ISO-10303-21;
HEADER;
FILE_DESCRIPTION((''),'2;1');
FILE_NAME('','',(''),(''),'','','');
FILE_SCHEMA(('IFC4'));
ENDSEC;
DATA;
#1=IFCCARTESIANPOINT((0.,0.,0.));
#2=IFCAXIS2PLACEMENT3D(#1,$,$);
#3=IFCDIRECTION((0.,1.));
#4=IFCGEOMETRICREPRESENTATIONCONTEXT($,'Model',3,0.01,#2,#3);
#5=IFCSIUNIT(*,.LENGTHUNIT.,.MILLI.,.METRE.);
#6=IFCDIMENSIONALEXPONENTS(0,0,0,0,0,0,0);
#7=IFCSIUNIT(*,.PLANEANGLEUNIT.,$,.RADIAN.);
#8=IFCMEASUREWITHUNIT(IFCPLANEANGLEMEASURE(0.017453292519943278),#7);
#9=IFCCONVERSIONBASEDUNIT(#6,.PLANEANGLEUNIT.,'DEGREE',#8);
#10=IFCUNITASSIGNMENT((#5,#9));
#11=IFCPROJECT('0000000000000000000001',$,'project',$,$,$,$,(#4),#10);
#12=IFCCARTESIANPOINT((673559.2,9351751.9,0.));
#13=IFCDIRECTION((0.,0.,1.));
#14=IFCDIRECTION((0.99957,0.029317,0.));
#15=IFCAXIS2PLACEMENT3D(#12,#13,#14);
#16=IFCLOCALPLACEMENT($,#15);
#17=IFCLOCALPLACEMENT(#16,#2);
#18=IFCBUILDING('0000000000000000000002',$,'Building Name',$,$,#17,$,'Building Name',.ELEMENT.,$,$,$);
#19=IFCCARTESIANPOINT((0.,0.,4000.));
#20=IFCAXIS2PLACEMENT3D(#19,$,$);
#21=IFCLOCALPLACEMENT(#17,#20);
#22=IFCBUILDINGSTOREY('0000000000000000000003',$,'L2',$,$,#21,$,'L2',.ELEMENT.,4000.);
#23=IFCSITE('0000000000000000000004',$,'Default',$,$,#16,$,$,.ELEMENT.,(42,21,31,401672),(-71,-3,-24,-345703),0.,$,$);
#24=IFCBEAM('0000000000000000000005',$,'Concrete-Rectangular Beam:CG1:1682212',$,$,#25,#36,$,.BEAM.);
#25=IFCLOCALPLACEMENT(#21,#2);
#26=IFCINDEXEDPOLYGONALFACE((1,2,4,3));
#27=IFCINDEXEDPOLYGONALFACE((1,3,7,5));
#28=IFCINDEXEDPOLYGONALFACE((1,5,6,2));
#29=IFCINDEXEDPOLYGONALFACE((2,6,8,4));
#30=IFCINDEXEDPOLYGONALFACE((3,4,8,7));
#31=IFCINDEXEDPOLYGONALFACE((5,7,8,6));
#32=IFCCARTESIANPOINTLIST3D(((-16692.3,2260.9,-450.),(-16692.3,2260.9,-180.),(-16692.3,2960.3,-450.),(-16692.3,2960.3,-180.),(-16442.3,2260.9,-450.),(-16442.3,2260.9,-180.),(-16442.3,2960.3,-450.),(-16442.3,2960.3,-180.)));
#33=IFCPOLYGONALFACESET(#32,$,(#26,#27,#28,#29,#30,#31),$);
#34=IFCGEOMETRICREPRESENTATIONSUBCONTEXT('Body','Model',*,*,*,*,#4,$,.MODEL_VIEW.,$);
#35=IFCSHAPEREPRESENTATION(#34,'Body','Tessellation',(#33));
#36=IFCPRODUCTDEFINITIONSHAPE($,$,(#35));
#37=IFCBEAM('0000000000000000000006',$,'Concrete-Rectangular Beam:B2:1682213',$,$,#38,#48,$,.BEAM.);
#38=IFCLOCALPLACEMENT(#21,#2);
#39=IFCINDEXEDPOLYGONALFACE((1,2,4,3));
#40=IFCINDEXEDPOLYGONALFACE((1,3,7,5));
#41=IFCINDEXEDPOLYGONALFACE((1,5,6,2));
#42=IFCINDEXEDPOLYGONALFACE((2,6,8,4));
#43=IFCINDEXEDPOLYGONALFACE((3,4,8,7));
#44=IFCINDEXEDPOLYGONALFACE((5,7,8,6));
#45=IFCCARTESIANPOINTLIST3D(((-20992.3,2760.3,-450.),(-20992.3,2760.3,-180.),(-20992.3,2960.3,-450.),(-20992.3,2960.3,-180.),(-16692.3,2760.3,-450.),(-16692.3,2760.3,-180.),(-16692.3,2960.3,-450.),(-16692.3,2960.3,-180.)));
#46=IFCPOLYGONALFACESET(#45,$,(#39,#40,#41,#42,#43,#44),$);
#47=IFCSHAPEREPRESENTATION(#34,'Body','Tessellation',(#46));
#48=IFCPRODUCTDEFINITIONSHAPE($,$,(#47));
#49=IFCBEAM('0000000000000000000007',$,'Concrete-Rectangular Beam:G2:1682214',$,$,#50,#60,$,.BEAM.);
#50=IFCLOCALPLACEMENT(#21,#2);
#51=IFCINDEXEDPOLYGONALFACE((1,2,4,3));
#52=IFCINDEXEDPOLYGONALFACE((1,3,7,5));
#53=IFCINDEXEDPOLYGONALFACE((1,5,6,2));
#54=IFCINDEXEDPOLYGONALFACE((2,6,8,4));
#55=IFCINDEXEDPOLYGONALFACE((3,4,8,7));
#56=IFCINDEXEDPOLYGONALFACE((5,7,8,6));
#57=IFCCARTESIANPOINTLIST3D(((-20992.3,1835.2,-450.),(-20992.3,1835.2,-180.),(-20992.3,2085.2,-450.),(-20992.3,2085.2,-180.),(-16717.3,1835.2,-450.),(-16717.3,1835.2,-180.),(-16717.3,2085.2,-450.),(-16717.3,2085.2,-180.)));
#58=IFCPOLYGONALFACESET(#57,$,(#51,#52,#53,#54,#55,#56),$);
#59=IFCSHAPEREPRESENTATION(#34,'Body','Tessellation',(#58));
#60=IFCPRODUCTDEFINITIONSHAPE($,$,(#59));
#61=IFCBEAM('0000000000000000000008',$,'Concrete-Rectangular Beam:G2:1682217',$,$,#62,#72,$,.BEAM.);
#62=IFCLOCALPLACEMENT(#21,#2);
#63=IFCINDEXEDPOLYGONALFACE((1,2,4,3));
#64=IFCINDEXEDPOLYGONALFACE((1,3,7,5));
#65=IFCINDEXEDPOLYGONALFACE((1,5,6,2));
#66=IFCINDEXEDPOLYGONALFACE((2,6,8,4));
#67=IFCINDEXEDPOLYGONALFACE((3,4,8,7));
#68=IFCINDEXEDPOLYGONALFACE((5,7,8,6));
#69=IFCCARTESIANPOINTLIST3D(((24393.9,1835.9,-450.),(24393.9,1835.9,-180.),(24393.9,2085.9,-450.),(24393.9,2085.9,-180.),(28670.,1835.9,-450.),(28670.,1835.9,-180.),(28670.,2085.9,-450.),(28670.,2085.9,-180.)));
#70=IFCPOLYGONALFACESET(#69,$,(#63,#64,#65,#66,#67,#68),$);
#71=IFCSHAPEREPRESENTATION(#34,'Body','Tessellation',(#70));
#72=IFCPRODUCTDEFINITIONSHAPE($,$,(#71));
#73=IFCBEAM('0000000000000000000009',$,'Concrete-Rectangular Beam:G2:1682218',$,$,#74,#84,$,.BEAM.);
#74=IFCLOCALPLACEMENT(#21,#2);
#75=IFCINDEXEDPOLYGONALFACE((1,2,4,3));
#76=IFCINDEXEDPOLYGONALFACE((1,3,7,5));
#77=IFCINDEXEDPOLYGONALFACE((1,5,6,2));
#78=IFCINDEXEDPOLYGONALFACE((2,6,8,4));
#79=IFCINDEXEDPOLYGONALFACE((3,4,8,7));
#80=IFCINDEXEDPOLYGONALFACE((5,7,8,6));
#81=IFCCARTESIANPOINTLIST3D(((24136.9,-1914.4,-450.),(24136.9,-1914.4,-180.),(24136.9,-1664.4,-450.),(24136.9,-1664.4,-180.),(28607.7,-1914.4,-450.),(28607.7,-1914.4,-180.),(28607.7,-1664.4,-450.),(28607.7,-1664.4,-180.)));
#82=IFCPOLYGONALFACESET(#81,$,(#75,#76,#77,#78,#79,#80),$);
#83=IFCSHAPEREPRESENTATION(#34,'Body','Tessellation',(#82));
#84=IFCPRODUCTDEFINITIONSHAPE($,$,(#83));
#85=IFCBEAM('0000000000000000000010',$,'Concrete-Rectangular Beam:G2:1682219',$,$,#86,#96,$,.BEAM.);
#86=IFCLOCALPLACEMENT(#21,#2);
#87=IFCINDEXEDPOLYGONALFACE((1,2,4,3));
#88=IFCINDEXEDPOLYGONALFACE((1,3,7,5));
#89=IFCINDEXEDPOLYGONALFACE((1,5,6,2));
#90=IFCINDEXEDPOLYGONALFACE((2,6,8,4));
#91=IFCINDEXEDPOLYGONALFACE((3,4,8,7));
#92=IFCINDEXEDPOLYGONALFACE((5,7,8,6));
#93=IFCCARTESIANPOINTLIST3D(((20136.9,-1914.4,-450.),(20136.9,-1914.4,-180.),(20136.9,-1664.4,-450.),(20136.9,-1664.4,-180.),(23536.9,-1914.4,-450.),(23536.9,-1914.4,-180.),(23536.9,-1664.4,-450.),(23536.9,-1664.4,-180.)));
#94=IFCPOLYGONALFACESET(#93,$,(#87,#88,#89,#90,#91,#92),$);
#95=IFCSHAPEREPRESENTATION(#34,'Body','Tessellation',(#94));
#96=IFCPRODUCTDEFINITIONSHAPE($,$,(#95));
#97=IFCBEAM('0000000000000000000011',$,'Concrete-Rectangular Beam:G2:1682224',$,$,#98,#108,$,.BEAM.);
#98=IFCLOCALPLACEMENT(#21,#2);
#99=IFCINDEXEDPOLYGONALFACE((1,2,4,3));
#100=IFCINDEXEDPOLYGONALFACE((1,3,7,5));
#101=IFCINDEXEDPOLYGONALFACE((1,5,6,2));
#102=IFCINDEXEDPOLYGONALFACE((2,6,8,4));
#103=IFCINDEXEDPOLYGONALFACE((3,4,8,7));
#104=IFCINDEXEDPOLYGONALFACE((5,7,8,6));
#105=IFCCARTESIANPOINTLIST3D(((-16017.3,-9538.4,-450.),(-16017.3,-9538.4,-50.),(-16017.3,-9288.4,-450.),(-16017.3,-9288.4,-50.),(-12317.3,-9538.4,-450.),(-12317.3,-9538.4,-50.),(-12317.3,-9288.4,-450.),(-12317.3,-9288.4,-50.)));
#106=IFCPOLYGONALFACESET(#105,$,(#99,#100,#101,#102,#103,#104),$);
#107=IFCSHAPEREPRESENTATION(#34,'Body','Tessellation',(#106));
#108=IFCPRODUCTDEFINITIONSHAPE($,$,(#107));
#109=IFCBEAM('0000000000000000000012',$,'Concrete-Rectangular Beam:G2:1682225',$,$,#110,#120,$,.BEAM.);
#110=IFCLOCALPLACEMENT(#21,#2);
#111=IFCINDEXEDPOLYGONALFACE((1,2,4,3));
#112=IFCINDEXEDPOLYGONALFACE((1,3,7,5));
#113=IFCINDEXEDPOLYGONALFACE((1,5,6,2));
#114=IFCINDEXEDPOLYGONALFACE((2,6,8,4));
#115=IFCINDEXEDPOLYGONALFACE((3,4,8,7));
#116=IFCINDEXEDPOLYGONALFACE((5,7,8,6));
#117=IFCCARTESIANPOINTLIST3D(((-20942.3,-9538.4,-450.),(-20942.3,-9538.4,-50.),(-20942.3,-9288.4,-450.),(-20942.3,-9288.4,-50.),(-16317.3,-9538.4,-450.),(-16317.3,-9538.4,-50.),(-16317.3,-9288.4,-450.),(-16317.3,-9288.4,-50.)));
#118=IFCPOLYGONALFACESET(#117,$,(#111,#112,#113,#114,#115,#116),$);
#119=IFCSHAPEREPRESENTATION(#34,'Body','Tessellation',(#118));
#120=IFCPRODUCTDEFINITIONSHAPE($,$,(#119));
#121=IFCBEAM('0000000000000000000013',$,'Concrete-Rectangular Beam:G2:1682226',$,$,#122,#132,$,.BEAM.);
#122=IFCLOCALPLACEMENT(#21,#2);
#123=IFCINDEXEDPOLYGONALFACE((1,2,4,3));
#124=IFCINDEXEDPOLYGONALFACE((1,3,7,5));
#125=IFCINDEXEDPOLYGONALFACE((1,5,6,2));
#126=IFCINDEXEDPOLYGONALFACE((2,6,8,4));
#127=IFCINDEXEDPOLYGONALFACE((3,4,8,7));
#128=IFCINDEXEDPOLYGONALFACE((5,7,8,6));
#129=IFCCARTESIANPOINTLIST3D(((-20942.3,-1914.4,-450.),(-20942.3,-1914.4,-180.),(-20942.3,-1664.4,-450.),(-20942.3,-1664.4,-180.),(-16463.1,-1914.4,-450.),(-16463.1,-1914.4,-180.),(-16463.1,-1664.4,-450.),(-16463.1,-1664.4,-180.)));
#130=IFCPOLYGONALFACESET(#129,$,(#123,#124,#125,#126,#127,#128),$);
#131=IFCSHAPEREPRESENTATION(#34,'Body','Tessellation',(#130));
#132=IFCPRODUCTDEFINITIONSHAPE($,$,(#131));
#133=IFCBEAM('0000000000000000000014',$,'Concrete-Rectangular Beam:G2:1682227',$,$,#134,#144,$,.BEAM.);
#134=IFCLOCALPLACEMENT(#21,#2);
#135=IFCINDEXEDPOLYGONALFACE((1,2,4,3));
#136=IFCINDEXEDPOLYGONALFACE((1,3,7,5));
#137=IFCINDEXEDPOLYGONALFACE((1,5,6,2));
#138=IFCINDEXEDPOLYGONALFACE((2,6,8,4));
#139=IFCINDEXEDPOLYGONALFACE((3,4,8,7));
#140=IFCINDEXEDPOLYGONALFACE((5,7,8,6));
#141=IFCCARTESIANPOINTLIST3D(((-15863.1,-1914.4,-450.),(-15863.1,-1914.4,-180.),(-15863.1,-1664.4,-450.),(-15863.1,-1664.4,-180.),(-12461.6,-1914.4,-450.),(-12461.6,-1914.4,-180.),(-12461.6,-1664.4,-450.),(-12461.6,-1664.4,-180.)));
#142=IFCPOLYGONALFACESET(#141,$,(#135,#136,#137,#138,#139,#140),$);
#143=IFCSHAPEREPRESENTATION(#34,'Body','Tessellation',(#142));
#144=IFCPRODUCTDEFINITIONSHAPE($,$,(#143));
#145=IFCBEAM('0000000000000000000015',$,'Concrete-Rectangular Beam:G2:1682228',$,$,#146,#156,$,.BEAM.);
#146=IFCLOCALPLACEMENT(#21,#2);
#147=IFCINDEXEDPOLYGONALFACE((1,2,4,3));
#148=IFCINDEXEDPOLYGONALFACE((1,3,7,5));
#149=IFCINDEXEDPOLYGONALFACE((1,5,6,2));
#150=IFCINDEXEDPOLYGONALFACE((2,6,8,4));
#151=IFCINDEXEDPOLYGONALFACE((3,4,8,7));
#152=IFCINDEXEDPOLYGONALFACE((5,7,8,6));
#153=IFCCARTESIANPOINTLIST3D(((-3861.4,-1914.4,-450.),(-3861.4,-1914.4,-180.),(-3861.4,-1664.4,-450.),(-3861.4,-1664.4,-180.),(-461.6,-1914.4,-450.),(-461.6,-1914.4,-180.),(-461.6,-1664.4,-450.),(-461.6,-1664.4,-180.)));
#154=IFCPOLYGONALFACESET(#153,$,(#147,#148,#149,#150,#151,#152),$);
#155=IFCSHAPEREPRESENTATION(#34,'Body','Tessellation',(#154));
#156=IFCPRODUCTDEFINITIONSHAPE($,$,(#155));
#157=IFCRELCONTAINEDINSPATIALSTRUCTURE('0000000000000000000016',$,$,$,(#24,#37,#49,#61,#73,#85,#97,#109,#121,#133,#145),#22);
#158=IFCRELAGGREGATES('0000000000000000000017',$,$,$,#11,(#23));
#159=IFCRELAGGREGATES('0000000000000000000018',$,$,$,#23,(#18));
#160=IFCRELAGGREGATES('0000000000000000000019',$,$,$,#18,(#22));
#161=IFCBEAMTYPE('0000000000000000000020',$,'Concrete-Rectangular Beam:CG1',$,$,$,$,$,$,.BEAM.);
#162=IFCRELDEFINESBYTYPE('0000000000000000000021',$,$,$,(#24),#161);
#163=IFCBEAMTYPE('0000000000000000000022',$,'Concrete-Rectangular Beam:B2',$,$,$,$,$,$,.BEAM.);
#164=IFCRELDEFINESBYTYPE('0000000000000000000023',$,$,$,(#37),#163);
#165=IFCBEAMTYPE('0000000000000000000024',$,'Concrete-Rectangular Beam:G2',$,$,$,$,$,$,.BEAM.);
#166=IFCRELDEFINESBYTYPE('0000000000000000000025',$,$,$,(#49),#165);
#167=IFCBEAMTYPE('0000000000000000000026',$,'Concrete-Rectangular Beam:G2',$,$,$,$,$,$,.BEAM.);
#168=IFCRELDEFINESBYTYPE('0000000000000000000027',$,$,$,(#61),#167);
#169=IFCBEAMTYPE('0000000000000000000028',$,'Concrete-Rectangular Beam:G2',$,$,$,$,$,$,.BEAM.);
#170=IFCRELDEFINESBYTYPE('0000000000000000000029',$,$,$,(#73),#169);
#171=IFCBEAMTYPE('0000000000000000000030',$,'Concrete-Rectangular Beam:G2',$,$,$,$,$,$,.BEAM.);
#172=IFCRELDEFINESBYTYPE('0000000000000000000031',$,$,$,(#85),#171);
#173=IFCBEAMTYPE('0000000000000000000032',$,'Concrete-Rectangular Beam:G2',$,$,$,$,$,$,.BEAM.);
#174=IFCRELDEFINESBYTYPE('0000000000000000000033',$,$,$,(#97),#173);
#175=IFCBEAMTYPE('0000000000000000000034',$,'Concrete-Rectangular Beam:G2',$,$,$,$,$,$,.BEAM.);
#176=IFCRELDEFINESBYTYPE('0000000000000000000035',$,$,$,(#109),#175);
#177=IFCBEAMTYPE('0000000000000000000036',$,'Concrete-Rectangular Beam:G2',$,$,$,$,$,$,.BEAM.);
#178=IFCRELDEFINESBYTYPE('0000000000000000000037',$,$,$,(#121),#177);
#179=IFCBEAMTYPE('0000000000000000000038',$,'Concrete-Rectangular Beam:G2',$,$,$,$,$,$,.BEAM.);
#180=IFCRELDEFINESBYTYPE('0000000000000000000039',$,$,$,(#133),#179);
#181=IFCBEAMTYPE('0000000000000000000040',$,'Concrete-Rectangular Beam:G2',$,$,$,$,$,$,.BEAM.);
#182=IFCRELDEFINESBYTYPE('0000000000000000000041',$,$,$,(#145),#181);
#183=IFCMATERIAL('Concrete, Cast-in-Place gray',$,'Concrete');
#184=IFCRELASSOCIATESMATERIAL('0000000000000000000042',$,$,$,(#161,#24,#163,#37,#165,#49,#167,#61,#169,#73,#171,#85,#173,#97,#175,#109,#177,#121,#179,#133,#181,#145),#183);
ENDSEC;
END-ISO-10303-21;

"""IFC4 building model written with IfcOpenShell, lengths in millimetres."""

from ifc_helpers import new_model, entity, si_unit, converted_unit, direction, frame, origin, place, context, subcontext, project, spatial, indexed_curve, outline, extrude, source, transform, mapped, material, type_object, type_shapes, element, save


model = new_model("IFC4")

# Units and contexts
model_context = context("Model", 3, precision=0.01, world=origin(), true_north=direction((0.0, 1.0)))
body_context = subcontext(model_context, "Body", "Model", "MODEL_VIEW")
ifc_project = project(units=[si_unit("LENGTHUNIT", "METRE", prefix="MILLI"), converted_unit("PLANEANGLEUNIT", "DEGREE", entity("IfcPlaneAngleMeasure", 0.017453292519943278), si_unit("PLANEANGLEUNIT", "RADIAN"), dimensions=[0, 0, 0, 0, 0, 0, 0])], contexts=[model_context])

# Site, building, storey
site_placement = place(None, frame((673559.2, 9351751.9, 0.0), z_axis=(0.0, 0.0, 1.0), x_axis=(0.99957, 0.029317, 0.0)))
site = spatial("IfcSite", under=ifc_project, at=site_placement, Name="Default", CompositionType="ELEMENT", RefLatitude=(42, 21, 31, 401672), RefLongitude=(-71, -3, -24, -345703), RefElevation=0.0)
building_placement = place(site_placement, origin())
building = spatial("IfcBuilding", under=site, at=building_placement, Name="Building Name", LongName="Building Name", CompositionType="ELEMENT")
storey_placement = place(building_placement, frame((0.0, 0.0, 4000.0)))
storey = spatial("IfcBuildingStorey", under=building, at=storey_placement, Name="L2", LongName="L2", CompositionType="ELEMENT", Elevation=4000.0)

# Beams
ifc_material = material(Name="Concrete, Cast-in-Place gray", Category="Concrete")
beam_type_1 = type_object("IfcBeamType", Name="Concrete-Rectangular Beam:CG1", PredefinedType="BEAM", material=ifc_material)
shared_shape_1 = source(origin(), body_context, "Body", "SweptSolid", [
    extrude(outline(indexed_curve([(-125.0, -135.0), (125.0, -135.0), (125.0, 135.0), (-125.0, 135.0), (-125.0, -135.0)], self_intersect=False)), frame((-16567.3, 2260.9, 3685.0), z_axis=(0.0, 1.0, 0.0), x_axis=(-1.0, 0.0, 0.0)), (0.0, 0.0, 1.0), 699.4),
])
type_shapes(beam_type_1, [shared_shape_1])
beam_1_placement = place(storey_placement, frame((0.0, 0.0, -4000.0)))
element("IfcBeam", 1, at=beam_1_placement, inside=storey, type_object=beam_type_1, material=ifc_material, Name="Concrete-Rectangular Beam:CG1:1682212", PredefinedType="BEAM", context=body_context, shape_type="MappedRepresentation", body=[
    mapped(shared_shape_1, transform((0.0, 0.0, 0.0), scale=1.0)),
])
beam_type_2 = type_object("IfcBeamType", Name="Concrete-Rectangular Beam:B2", PredefinedType="BEAM", material=ifc_material)
shared_shape_2 = source(origin(), body_context, "Body", "SweptSolid", [
    extrude(outline(indexed_curve([(-135.0, -100.0), (135.0, -100.0), (135.0, 100.0), (-135.0, 100.0), (-135.0, -100.0)], self_intersect=False)), frame((-20992.3, 2860.3, 3685.0), z_axis=(1.0, 0.0, 0.0), x_axis=(0.0, 0.0, -1.0)), (0.0, 0.0, 1.0), 4300.0),
])
type_shapes(beam_type_2, [shared_shape_2])
beam_2_placement = place(storey_placement, frame((0.0, 0.0, -4000.0)))
element("IfcBeam", 2, at=beam_2_placement, inside=storey, type_object=beam_type_2, material=ifc_material, Name="Concrete-Rectangular Beam:B2:1682213", PredefinedType="BEAM", context=body_context, shape_type="MappedRepresentation", body=[
    mapped(shared_shape_2, transform((0.0, 0.0, 0.0), scale=1.0)),
])
beam_type_3 = type_object("IfcBeamType", Name="Concrete-Rectangular Beam:G2", PredefinedType="BEAM", material=ifc_material)
shared_shape_3 = source(origin(), body_context, "Body", "SweptSolid", [
    extrude(outline(indexed_curve([(-135.0, -125.0), (135.0, -125.0), (135.0, 125.0), (-135.0, 125.0), (-135.0, -125.0)], self_intersect=False)), frame((-20992.3, 1960.2, 3685.0), z_axis=(1.0, 0.0, 0.0), x_axis=(0.0, 0.0, -1.0)), (0.0, 0.0, 1.0), 4275.0),
])
type_shapes(beam_type_3, [shared_shape_3])
beam_3_placement = place(storey_placement, frame((0.0, 0.0, -4000.0)))
element("IfcBeam", 3, at=beam_3_placement, inside=storey, type_object=beam_type_3, material=ifc_material, Name="Concrete-Rectangular Beam:G2:1682214", PredefinedType="BEAM", context=body_context, shape_type="MappedRepresentation", body=[
    mapped(shared_shape_3, transform((0.0, 0.0, 0.0), scale=1.0)),
])
beam_type_4 = type_object("IfcBeamType", Name="Concrete-Rectangular Beam:G2", PredefinedType="BEAM", material=ifc_material)
shared_shape_4 = source(origin(), body_context, "Body", "SweptSolid", [
    extrude(outline(indexed_curve([(-135.0, -125.0), (135.0, -125.0), (135.0, 125.0), (-135.0, 125.0), (-135.0, -125.0)], self_intersect=False)), frame((28670.0, 1960.9, 3685.0), z_axis=(-1.0, 0.0, 0.0), x_axis=(0.0, 0.0, -1.0)), (0.0, 0.0, 1.0), 4276.1),
])
type_shapes(beam_type_4, [shared_shape_4])
beam_4_placement = place(storey_placement, frame((0.0, 0.0, -4000.0)))
element("IfcBeam", 4, at=beam_4_placement, inside=storey, type_object=beam_type_4, material=ifc_material, Name="Concrete-Rectangular Beam:G2:1682217", PredefinedType="BEAM", context=body_context, shape_type="MappedRepresentation", body=[
    mapped(shared_shape_4, transform((0.0, 0.0, 0.0), scale=1.0)),
])
beam_type_5 = type_object("IfcBeamType", Name="Concrete-Rectangular Beam:G2", PredefinedType="BEAM", material=ifc_material)
shared_shape_5 = source(origin(), body_context, "Body", "SweptSolid", [
    extrude(outline(indexed_curve([(-135.0, -125.0), (135.0, -125.0), (135.0, 125.0), (-135.0, 125.0), (-135.0, -125.0)], self_intersect=False)), frame((28607.7, -1789.4, 3685.0), z_axis=(-1.0, 0.0, 0.0), x_axis=(0.0, 0.0, -1.0)), (0.0, 0.0, 1.0), 4470.8),
])
type_shapes(beam_type_5, [shared_shape_5])
beam_5_placement = place(storey_placement, frame((0.0, 0.0, -4000.0)))
element("IfcBeam", 5, at=beam_5_placement, inside=storey, type_object=beam_type_5, material=ifc_material, Name="Concrete-Rectangular Beam:G2:1682218", PredefinedType="BEAM", context=body_context, shape_type="MappedRepresentation", body=[
    mapped(shared_shape_5, transform((0.0, 0.0, 0.0), scale=1.0)),
])
beam_type_6 = type_object("IfcBeamType", Name="Concrete-Rectangular Beam:G2", PredefinedType="BEAM", material=ifc_material)
shared_shape_6 = source(origin(), body_context, "Body", "SweptSolid", [
    extrude(outline(indexed_curve([(-135.0, -125.0), (135.0, -125.0), (135.0, 125.0), (-135.0, 125.0), (-135.0, -125.0)], self_intersect=False)), frame((23536.9, -1789.4, 3685.0), z_axis=(-1.0, 0.0, 0.0), x_axis=(0.0, 0.0, -1.0)), (0.0, 0.0, 1.0), 3400.0),
])
type_shapes(beam_type_6, [shared_shape_6])
beam_6_placement = place(storey_placement, frame((0.0, 0.0, -4000.0)))
element("IfcBeam", 6, at=beam_6_placement, inside=storey, type_object=beam_type_6, material=ifc_material, Name="Concrete-Rectangular Beam:G2:1682219", PredefinedType="BEAM", context=body_context, shape_type="MappedRepresentation", body=[
    mapped(shared_shape_6, transform((0.0, 0.0, 0.0), scale=1.0)),
])
beam_type_7 = type_object("IfcBeamType", Name="Concrete-Rectangular Beam:G2", PredefinedType="BEAM", material=ifc_material)
shared_shape_7 = source(origin(), body_context, "Body", "SweptSolid", [
    extrude(outline(indexed_curve([(-200.0, -125.0), (200.0, -125.0), (200.0, 125.0), (-200.0, 125.0), (-200.0, -125.0)], self_intersect=False)), frame((-12317.3, -9413.4, 3750.0), z_axis=(-1.0, 0.0, 0.0), x_axis=(0.0, 0.0, -1.0)), (0.0, 0.0, 1.0), 3700.0),
])
type_shapes(beam_type_7, [shared_shape_7])
beam_7_placement = place(storey_placement, frame((0.0, 0.0, -4000.0)))
element("IfcBeam", 7, at=beam_7_placement, inside=storey, type_object=beam_type_7, material=ifc_material, Name="Concrete-Rectangular Beam:G2:1682224", PredefinedType="BEAM", context=body_context, shape_type="MappedRepresentation", body=[
    mapped(shared_shape_7, transform((0.0, 0.0, 0.0), scale=1.0)),
])
beam_type_8 = type_object("IfcBeamType", Name="Concrete-Rectangular Beam:G2", PredefinedType="BEAM", material=ifc_material)
shared_shape_8 = source(origin(), body_context, "Body", "SweptSolid", [
    extrude(outline(indexed_curve([(-200.0, -125.0), (200.0, -125.0), (200.0, 125.0), (-200.0, 125.0), (-200.0, -125.0)], self_intersect=False)), frame((-16317.3, -9413.4, 3750.0), z_axis=(-1.0, 0.0, 0.0), x_axis=(0.0, 0.0, -1.0)), (0.0, 0.0, 1.0), 4625.0),
])
type_shapes(beam_type_8, [shared_shape_8])
beam_8_placement = place(storey_placement, frame((0.0, 0.0, -4000.0)))
element("IfcBeam", 8, at=beam_8_placement, inside=storey, type_object=beam_type_8, material=ifc_material, Name="Concrete-Rectangular Beam:G2:1682225", PredefinedType="BEAM", context=body_context, shape_type="MappedRepresentation", body=[
    mapped(shared_shape_8, transform((0.0, 0.0, 0.0), scale=1.0)),
])
beam_type_9 = type_object("IfcBeamType", Name="Concrete-Rectangular Beam:G2", PredefinedType="BEAM", material=ifc_material)
shared_shape_9 = source(origin(), body_context, "Body", "SweptSolid", [
    extrude(outline(indexed_curve([(-135.0, -125.0), (135.0, -125.0), (135.0, 125.0), (-135.0, 125.0), (-135.0, -125.0)], self_intersect=False)), frame((-20942.3, -1789.4, 3685.0), z_axis=(1.0, 0.0, 0.0), x_axis=(0.0, 0.0, -1.0)), (0.0, 0.0, 1.0), 4479.2),
])
type_shapes(beam_type_9, [shared_shape_9])
beam_9_placement = place(storey_placement, frame((0.0, 0.0, -4000.0)))
element("IfcBeam", 9, at=beam_9_placement, inside=storey, type_object=beam_type_9, material=ifc_material, Name="Concrete-Rectangular Beam:G2:1682226", PredefinedType="BEAM", context=body_context, shape_type="MappedRepresentation", body=[
    mapped(shared_shape_9, transform((0.0, 0.0, 0.0), scale=1.0)),
])
beam_type_10 = type_object("IfcBeamType", Name="Concrete-Rectangular Beam:G2", PredefinedType="BEAM", material=ifc_material)
shared_shape_10 = source(origin(), body_context, "Body", "SweptSolid", [
    extrude(outline(indexed_curve([(-135.0, -125.0), (135.0, -125.0), (135.0, 125.0), (-135.0, 125.0), (-135.0, -125.0)], self_intersect=False)), frame((-15863.1, -1789.4, 3685.0), z_axis=(1.0, 0.0, 0.0), x_axis=(0.0, 0.0, -1.0)), (0.0, 0.0, 1.0), 3401.5),
])
type_shapes(beam_type_10, [shared_shape_10])
beam_10_placement = place(storey_placement, frame((0.0, 0.0, -4000.0)))
element("IfcBeam", 10, at=beam_10_placement, inside=storey, type_object=beam_type_10, material=ifc_material, Name="Concrete-Rectangular Beam:G2:1682227", PredefinedType="BEAM", context=body_context, shape_type="MappedRepresentation", body=[
    mapped(shared_shape_10, transform((0.0, 0.0, 0.0), scale=1.0)),
])
beam_type_11 = type_object("IfcBeamType", Name="Concrete-Rectangular Beam:G2", PredefinedType="BEAM", material=ifc_material)
shared_shape_11 = source(origin(), body_context, "Body", "SweptSolid", [
    extrude(outline(indexed_curve([(-135.0, -125.0), (135.0, -125.0), (135.0, 125.0), (-135.0, 125.0), (-135.0, -125.0)], self_intersect=False)), frame((-461.6, -1789.4, 3685.0), z_axis=(-1.0, 0.0, 0.0), x_axis=(0.0, 0.0, -1.0)), (0.0, 0.0, 1.0), 3399.7),
])
type_shapes(beam_type_11, [shared_shape_11])
beam_11_placement = place(storey_placement, frame((0.0, 0.0, -4000.0)))
element("IfcBeam", 11, at=beam_11_placement, inside=storey, type_object=beam_type_11, material=ifc_material, Name="Concrete-Rectangular Beam:G2:1682228", PredefinedType="BEAM", context=body_context, shape_type="MappedRepresentation", body=[
    mapped(shared_shape_11, transform((0.0, 0.0, 0.0), scale=1.0)),
])

save(model, "model.ifc")
